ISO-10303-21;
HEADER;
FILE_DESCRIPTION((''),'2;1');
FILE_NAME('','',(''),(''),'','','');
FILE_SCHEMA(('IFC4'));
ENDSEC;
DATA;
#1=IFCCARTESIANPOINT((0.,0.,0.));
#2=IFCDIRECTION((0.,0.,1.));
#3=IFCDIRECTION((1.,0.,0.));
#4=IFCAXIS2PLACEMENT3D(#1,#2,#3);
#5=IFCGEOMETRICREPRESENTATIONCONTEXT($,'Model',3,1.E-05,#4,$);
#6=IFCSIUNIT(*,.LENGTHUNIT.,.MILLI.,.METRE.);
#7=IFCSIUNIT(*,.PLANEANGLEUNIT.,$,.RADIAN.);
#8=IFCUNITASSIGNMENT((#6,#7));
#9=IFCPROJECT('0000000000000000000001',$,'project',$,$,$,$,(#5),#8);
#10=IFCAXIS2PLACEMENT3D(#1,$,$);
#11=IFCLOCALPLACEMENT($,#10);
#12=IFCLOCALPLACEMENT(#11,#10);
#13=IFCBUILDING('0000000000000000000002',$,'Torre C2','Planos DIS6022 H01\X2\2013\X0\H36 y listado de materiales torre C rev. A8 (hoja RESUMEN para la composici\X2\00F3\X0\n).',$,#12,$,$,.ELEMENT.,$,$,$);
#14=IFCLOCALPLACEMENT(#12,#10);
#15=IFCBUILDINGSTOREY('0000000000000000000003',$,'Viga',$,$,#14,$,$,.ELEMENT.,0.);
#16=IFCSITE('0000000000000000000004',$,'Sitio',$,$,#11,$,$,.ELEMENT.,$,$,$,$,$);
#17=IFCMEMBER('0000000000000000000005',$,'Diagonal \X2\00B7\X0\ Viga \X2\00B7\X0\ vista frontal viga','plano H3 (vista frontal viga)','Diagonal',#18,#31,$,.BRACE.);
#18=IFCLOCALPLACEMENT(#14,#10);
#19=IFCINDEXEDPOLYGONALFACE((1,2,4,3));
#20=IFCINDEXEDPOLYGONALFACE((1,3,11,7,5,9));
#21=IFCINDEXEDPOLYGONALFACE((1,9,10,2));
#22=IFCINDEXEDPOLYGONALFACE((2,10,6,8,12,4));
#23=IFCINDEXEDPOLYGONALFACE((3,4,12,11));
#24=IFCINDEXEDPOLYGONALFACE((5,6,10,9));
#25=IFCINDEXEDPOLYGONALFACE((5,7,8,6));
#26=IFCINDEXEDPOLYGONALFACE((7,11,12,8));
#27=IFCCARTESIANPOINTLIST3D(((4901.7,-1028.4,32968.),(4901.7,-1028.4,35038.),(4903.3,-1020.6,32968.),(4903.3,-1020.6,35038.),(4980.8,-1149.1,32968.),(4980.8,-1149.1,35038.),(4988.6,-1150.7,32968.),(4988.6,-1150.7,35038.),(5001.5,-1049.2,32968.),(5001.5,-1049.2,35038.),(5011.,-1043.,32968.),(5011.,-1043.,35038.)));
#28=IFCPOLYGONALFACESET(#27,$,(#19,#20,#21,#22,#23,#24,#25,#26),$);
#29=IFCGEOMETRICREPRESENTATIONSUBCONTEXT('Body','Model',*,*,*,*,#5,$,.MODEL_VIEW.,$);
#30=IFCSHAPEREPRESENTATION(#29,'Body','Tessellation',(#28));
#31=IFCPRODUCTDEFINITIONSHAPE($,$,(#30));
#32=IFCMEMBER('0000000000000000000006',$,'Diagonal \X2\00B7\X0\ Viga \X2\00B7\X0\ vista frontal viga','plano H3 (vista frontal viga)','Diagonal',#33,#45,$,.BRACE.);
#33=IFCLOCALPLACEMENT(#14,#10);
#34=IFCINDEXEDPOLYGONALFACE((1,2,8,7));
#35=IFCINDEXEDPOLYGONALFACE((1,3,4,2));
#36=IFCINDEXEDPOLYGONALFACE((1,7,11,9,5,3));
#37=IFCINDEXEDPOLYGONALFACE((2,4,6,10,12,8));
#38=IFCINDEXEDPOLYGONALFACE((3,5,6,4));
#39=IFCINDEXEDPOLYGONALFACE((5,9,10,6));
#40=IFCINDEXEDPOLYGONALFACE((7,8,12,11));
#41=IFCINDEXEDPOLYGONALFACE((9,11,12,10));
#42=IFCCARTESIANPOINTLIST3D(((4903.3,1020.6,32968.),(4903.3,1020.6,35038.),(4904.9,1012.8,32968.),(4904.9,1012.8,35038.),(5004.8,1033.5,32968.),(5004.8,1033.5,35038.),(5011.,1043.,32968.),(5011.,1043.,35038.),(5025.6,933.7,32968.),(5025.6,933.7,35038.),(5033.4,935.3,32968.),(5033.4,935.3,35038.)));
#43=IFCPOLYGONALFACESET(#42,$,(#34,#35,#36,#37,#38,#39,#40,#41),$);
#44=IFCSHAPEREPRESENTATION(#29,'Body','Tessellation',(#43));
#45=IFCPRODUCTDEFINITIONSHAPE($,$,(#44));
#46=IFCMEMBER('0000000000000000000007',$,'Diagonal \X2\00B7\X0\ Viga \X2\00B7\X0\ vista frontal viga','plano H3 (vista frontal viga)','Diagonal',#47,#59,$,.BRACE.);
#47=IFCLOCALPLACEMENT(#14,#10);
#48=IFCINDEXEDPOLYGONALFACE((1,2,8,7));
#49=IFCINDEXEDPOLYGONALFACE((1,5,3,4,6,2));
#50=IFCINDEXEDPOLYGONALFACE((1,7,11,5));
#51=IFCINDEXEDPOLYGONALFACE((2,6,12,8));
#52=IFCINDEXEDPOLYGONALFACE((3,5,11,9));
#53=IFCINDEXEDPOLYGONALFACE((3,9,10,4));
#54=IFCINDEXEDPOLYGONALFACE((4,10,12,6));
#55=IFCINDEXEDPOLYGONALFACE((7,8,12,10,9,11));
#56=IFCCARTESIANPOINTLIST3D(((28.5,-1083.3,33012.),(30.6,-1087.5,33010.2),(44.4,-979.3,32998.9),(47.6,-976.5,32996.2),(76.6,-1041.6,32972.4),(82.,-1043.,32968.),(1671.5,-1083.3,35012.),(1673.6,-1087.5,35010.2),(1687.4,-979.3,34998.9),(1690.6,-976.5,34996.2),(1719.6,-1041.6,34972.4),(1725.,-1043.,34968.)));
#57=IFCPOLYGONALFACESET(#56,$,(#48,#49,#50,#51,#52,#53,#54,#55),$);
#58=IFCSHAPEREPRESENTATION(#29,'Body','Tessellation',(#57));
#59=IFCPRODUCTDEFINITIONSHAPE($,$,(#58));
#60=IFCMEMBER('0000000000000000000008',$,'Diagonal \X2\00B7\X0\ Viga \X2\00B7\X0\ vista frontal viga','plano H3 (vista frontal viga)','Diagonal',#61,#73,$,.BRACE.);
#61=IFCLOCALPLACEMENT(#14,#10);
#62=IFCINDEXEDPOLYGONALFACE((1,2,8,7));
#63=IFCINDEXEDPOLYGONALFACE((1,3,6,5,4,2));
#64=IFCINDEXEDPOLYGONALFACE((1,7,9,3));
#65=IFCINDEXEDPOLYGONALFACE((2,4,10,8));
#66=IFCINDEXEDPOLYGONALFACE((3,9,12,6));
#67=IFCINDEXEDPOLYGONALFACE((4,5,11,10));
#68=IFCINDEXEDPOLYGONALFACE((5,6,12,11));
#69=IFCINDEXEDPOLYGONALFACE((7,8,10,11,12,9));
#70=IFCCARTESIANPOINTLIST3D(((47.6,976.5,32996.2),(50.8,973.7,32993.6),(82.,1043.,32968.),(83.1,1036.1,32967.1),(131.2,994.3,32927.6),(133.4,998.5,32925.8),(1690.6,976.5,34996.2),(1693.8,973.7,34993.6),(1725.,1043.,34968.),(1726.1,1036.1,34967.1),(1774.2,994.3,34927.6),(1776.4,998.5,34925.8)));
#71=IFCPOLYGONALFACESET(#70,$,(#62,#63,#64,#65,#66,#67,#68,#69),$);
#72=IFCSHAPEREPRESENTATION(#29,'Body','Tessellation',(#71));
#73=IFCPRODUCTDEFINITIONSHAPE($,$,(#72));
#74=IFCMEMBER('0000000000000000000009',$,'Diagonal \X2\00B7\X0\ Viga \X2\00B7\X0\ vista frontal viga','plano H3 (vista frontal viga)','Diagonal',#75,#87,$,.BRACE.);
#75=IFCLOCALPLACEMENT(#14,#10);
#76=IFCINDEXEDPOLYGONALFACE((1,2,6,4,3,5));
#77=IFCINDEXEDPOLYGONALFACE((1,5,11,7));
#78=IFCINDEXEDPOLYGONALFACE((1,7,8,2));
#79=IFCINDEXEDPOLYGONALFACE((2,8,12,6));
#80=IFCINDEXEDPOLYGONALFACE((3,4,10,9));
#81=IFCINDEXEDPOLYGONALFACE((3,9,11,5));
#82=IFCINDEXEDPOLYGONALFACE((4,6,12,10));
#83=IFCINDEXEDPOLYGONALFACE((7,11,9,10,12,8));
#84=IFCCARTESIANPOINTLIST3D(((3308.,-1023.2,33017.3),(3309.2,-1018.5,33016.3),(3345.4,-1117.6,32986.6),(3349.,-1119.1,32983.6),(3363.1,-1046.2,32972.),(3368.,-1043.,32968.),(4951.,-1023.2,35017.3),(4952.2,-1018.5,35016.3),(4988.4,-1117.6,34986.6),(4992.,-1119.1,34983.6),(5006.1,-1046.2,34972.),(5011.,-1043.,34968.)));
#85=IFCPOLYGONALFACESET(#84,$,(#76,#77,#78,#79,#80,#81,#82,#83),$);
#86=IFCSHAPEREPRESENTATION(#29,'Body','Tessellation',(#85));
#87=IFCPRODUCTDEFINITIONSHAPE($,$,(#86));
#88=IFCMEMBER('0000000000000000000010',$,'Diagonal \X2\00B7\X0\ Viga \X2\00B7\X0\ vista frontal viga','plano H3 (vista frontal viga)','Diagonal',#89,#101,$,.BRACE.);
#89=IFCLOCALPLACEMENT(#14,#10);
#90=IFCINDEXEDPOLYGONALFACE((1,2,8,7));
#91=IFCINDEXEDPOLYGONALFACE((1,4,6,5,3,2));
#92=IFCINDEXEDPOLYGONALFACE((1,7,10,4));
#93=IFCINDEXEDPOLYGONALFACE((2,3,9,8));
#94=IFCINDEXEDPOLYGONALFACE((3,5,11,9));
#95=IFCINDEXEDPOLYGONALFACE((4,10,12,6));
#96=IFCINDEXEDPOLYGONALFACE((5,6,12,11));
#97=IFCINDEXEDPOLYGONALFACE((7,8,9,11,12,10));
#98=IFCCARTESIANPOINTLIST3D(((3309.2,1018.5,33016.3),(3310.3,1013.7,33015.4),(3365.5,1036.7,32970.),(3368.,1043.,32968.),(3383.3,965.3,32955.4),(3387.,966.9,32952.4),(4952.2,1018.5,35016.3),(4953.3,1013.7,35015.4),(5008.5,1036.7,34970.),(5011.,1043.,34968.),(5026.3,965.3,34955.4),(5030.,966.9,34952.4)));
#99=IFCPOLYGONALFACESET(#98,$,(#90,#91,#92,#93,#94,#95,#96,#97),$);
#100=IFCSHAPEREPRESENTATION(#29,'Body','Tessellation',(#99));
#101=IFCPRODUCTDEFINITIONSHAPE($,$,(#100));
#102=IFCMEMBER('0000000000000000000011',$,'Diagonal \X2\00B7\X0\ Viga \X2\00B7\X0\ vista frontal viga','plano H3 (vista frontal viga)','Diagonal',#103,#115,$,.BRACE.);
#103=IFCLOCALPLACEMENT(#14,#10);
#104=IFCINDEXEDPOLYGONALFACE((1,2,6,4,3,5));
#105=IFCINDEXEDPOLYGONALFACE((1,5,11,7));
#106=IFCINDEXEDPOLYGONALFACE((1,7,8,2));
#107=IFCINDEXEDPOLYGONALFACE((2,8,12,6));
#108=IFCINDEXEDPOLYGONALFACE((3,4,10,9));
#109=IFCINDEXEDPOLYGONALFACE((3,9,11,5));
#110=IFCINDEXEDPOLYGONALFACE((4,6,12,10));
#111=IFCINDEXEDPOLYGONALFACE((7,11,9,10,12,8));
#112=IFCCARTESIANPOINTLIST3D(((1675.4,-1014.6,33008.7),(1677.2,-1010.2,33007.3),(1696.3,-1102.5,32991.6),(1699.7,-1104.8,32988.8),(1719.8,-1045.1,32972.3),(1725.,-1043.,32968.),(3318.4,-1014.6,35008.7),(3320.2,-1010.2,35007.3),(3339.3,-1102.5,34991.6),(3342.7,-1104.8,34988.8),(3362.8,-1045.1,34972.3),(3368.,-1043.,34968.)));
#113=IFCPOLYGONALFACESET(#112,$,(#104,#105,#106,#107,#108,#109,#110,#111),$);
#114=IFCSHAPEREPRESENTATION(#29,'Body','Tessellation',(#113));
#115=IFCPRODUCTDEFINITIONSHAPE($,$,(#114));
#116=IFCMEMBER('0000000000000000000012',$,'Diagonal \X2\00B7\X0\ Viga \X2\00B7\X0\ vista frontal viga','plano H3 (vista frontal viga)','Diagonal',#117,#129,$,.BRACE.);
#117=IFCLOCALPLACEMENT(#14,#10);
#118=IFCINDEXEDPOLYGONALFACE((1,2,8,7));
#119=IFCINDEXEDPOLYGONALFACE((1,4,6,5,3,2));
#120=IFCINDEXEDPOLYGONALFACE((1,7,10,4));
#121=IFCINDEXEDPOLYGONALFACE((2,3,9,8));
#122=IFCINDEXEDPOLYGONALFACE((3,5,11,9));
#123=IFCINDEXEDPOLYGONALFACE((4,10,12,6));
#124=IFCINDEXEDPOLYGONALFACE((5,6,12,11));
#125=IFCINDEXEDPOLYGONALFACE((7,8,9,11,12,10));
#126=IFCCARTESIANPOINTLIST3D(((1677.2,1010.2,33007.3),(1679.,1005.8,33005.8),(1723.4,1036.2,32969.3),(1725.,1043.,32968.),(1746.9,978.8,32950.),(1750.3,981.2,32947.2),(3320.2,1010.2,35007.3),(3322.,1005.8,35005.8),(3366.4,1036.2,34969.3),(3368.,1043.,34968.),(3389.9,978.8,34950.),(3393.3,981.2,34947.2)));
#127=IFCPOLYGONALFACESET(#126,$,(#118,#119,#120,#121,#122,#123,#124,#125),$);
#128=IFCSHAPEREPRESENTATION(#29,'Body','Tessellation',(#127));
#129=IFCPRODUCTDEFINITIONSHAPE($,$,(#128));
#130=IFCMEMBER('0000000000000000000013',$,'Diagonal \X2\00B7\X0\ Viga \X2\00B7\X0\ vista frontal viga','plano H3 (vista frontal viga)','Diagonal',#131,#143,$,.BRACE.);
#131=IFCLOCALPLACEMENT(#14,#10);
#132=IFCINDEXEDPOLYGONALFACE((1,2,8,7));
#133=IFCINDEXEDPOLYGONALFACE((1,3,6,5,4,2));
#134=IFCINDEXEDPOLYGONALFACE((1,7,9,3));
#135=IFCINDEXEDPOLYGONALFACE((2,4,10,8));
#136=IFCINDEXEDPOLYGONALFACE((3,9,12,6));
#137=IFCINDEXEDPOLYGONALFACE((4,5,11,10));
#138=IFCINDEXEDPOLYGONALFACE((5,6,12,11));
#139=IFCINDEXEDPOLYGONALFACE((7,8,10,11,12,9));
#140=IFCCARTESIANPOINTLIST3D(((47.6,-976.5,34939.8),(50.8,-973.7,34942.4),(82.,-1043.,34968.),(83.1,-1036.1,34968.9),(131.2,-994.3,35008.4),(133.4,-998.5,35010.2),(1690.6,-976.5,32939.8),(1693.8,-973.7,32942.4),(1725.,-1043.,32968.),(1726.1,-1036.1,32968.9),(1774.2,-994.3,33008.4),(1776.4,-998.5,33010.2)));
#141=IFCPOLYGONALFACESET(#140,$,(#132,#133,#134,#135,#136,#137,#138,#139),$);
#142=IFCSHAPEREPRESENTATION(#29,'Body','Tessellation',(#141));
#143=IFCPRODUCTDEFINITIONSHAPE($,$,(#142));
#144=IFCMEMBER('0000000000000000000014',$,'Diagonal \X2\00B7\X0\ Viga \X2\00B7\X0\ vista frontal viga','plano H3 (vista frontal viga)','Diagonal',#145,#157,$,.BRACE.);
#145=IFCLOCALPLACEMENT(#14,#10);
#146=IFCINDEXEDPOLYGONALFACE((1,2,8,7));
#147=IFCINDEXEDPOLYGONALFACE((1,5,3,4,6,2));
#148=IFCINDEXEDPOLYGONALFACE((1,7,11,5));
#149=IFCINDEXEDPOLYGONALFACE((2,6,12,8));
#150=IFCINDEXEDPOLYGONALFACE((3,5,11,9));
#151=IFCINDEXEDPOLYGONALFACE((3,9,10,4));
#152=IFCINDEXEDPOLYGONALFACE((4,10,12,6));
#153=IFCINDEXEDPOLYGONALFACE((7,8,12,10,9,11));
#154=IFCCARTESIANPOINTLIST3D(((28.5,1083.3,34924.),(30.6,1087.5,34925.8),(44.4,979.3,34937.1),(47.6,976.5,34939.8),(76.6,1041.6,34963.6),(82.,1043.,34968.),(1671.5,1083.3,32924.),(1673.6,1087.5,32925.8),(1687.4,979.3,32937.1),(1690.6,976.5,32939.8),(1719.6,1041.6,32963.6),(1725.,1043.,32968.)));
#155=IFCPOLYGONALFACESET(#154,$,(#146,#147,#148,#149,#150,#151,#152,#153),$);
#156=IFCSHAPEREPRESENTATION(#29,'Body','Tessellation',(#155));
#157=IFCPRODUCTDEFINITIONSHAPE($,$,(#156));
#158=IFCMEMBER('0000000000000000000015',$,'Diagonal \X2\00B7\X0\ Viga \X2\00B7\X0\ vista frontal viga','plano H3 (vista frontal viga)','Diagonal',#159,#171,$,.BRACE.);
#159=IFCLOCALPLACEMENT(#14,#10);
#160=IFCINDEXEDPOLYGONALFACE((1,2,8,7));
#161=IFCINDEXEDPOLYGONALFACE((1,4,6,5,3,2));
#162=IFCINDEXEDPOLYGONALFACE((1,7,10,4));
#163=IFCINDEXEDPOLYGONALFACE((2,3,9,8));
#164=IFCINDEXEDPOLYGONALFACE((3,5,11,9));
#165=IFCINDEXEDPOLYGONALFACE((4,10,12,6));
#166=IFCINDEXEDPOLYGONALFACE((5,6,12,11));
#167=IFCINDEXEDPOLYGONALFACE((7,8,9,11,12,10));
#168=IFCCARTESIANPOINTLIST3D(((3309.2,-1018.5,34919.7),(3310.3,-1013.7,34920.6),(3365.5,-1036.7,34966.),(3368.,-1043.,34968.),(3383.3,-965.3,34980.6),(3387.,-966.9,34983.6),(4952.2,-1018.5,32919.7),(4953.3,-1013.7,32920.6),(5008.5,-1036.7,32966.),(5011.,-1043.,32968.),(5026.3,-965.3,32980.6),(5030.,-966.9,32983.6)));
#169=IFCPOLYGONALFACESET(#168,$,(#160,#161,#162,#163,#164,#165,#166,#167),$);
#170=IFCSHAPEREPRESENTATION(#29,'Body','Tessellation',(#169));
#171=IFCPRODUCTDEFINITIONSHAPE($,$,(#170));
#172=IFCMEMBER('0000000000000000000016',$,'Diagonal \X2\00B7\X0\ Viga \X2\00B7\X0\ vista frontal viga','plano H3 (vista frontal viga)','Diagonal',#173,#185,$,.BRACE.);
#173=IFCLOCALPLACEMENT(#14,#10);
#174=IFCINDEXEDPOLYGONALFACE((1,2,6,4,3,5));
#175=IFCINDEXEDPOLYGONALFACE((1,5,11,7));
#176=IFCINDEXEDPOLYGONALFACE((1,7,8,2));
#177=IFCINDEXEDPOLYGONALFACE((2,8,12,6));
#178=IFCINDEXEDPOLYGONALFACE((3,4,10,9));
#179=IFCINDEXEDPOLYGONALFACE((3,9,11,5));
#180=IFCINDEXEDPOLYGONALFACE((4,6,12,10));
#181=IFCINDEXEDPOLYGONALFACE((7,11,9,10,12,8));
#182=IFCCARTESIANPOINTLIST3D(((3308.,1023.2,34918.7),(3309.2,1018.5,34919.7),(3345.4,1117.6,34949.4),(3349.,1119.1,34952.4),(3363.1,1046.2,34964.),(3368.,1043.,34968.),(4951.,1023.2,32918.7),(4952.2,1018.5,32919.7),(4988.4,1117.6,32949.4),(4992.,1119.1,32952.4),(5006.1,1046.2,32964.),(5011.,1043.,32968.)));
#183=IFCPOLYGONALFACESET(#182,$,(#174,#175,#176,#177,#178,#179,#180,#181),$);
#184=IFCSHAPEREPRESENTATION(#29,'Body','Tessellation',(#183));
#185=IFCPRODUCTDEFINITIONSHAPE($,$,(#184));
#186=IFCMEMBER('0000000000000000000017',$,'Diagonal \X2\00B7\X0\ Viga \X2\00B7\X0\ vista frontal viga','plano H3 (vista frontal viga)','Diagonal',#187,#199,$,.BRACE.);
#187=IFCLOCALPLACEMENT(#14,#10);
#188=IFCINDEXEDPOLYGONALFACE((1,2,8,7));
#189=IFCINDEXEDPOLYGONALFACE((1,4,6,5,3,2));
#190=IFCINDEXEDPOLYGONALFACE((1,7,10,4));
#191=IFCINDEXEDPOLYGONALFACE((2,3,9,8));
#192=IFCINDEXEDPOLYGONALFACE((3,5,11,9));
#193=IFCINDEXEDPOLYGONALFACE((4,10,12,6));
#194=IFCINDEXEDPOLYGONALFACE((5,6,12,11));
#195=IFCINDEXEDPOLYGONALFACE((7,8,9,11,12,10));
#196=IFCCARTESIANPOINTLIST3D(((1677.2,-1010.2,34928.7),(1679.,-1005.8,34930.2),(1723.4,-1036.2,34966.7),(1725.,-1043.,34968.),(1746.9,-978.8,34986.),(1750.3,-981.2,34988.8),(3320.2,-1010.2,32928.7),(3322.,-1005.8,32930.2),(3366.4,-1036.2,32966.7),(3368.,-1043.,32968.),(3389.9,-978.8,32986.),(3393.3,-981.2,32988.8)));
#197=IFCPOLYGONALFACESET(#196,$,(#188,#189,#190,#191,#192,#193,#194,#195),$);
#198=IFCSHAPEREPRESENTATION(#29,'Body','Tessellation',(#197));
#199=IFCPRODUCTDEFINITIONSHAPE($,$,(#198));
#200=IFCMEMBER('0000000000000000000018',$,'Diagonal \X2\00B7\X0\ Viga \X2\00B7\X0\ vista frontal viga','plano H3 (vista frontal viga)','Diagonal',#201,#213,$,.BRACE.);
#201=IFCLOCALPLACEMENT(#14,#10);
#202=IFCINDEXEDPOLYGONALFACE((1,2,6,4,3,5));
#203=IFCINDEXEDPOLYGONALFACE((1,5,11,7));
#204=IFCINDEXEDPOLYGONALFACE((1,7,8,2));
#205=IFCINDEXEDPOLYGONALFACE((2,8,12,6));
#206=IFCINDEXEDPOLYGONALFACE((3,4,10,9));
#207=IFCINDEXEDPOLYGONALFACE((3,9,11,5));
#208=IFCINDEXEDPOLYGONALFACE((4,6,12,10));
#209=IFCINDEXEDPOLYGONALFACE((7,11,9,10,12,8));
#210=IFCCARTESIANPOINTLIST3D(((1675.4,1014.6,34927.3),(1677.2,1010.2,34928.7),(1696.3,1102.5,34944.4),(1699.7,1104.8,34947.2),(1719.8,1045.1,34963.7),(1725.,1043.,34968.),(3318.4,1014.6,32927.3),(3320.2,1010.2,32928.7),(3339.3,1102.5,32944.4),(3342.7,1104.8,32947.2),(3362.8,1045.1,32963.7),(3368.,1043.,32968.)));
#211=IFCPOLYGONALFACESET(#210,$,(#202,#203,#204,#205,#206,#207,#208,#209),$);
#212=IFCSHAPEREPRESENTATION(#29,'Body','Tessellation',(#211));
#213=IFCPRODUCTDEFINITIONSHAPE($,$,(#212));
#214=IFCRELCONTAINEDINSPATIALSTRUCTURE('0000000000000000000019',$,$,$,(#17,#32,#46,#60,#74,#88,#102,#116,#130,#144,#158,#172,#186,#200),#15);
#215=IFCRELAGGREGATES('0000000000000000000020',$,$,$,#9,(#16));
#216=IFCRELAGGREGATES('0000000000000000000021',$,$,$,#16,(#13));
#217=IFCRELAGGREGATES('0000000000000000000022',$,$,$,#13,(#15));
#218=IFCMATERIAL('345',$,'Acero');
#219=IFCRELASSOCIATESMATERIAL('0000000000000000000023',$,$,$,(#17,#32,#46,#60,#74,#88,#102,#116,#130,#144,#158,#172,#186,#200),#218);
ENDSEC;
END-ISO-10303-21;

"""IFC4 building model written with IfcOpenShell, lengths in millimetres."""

from ifc_helpers import new_model, si_unit, frame, frame_2d, origin, origin_with_axes, place, context, subcontext, project, spatial, l_section, extrude, material, element, save


model = new_model("IFC4")

# Units and contexts
model_context = context("Model", 3, precision=1e-05, world=origin_with_axes())
body_context = subcontext(model_context, "Body", "Model", "MODEL_VIEW")
ifc_project = project(units=[si_unit("LENGTHUNIT", "METRE", prefix="MILLI"), si_unit("PLANEANGLEUNIT", "RADIAN")], contexts=[model_context])

# Site, building, storey
site_placement = place(None, origin())
site = spatial("IfcSite", under=ifc_project, at=site_placement, Name="Sitio", CompositionType="ELEMENT")
building_placement = place(site_placement, origin())
building = spatial("IfcBuilding", under=site, at=building_placement, Name="Torre C2", Description="Planos DIS6022 H01–H36 y listado de materiales torre C rev. A8 (hoja RESUMEN para la composición).", CompositionType="ELEMENT")
storey_placement = place(building_placement, origin())
storey = spatial("IfcBuildingStorey", under=building, at=storey_placement, Name="Viga", CompositionType="ELEMENT", Elevation=0.0)

# Members
ifc_material_1 = material(Name="345", Category="Acero")
for number, where, z_axis, x_axis, name in (
    (1, (5011.0, -1043.0, 32968.0), (0.0, 0.0, 1.0), (-0.979018, 0.203775, 0.0), "Diagonal · Viga · vista frontal viga"),
    (2, (5011.0, 1043.0, 32968.0), (0.0, 0.0, 1.0), (-0.979018, -0.203775, 0.0), "Diagonal · Viga · vista frontal viga"),
):
    element("IfcMember", number, at=place(storey_placement, frame(where, z_axis=z_axis, x_axis=x_axis)), inside=storey, material=ifc_material_1, Name=name, Description="plano H3 (vista frontal viga)", ObjectType="Diagonal", PredefinedType="BRACE", context=body_context, shape_type="SweptSolid", body=[
        extrude(l_section(Depth=110.0, Width=110.0, Thickness=8.0, at=frame_2d((55.0, 55.0))), None, (0.0, 0.0, 1.0), 2070.0),
    ])
for number, where, z_axis, x_axis, name in (
    (3, (82.0, -1043.0, 32968.0), (0.634772, 0.0, 0.772699), (-0.429809, 0.831019, 0.353088), "Diagonal · Viga · vista frontal viga"),
    (4, (82.0, 1043.0, 32968.0), (0.634772, 0.0, 0.772699), (-0.429809, -0.831019, 0.353088), "Diagonal · Viga · vista frontal viga"),
    (5, (3368.0, -1043.0, 32968.0), (0.634772, 0.0, 0.772699), (-0.735468, 0.306666, 0.604187), "Diagonal · Viga · vista frontal viga"),
    (6, (3368.0, 1043.0, 32968.0), (0.634772, 0.0, 0.772699), (-0.735468, -0.306666, 0.604187), "Diagonal · Viga · vista frontal viga"),
):
    element("IfcMember", number, at=place(storey_placement, frame(where, z_axis=z_axis, x_axis=x_axis)), inside=storey, material=ifc_material_1, Name=name, Description="plano H3 (vista frontal viga)", ObjectType="Diagonal", PredefinedType="BRACE", context=body_context, shape_type="SweptSolid", body=[
        extrude(l_section(Depth=80.0, Width=80.0, Thickness=5.0, at=frame_2d((40.0, 40.0))), None, (0.0, 0.0, 1.0), 2588.3),
    ])
for number, where, z_axis, x_axis, name in (
    (7, (1725.0, -1043.0, 32968.0), (0.634772, 0.0, 0.772699), (-0.682717, 0.468339, 0.560852), "Diagonal · Viga · vista frontal viga"),
    (8, (1725.0, 1043.0, 32968.0), (0.634772, 0.0, 0.772699), (-0.682717, -0.468339, 0.560852), "Diagonal · Viga · vista frontal viga"),
):
    element("IfcMember", number, at=place(storey_placement, frame(where, z_axis=z_axis, x_axis=x_axis)), inside=storey, material=ifc_material_1, Name=name, Description="plano H3 (vista frontal viga)", ObjectType="Diagonal", PredefinedType="BRACE", context=body_context, shape_type="SweptSolid", body=[
        extrude(l_section(Depth=70.0, Width=70.0, Thickness=5.0, at=frame_2d((35.0, 35.0))), None, (0.0, 0.0, 1.0), 2588.3),
    ])
for number, where, z_axis, x_axis, name in (
    (9, (82.0, -1043.0, 34968.0), (0.634772, 0.0, -0.772699), (-0.429809, 0.831019, -0.353088), "Diagonal · Viga · vista frontal viga"),
    (10, (82.0, 1043.0, 34968.0), (0.634772, 0.0, -0.772699), (-0.429809, -0.831019, -0.353088), "Diagonal · Viga · vista frontal viga"),
    (11, (3368.0, -1043.0, 34968.0), (0.634772, 0.0, -0.772699), (-0.735468, 0.306666, -0.604187), "Diagonal · Viga · vista frontal viga"),
    (12, (3368.0, 1043.0, 34968.0), (0.634772, 0.0, -0.772699), (-0.735468, -0.306666, -0.604187), "Diagonal · Viga · vista frontal viga"),
):
    element("IfcMember", number, at=place(storey_placement, frame(where, z_axis=z_axis, x_axis=x_axis)), inside=storey, material=ifc_material_1, Name=name, Description="plano H3 (vista frontal viga)", ObjectType="Diagonal", PredefinedType="BRACE", context=body_context, shape_type="SweptSolid", body=[
        extrude(l_section(Depth=80.0, Width=80.0, Thickness=5.0, at=frame_2d((40.0, 40.0))), None, (0.0, 0.0, 1.0), 2588.3),
    ])
for number, where, z_axis, x_axis, name in (
    (13, (1725.0, -1043.0, 34968.0), (0.634772, 0.0, -0.772699), (-0.682717, 0.468339, -0.560852), "Diagonal · Viga · vista frontal viga"),
    (14, (1725.0, 1043.0, 34968.0), (0.634772, 0.0, -0.772699), (-0.682717, -0.468339, -0.560852), "Diagonal · Viga · vista frontal viga"),
):
    element("IfcMember", number, at=place(storey_placement, frame(where, z_axis=z_axis, x_axis=x_axis)), inside=storey, material=ifc_material_1, Name=name, Description="plano H3 (vista frontal viga)", ObjectType="Diagonal", PredefinedType="BRACE", context=body_context, shape_type="SweptSolid", body=[
        extrude(l_section(Depth=70.0, Width=70.0, Thickness=5.0, at=frame_2d((35.0, 35.0))), None, (0.0, 0.0, 1.0), 2588.3),
    ])

save(model, "model.ifc")
